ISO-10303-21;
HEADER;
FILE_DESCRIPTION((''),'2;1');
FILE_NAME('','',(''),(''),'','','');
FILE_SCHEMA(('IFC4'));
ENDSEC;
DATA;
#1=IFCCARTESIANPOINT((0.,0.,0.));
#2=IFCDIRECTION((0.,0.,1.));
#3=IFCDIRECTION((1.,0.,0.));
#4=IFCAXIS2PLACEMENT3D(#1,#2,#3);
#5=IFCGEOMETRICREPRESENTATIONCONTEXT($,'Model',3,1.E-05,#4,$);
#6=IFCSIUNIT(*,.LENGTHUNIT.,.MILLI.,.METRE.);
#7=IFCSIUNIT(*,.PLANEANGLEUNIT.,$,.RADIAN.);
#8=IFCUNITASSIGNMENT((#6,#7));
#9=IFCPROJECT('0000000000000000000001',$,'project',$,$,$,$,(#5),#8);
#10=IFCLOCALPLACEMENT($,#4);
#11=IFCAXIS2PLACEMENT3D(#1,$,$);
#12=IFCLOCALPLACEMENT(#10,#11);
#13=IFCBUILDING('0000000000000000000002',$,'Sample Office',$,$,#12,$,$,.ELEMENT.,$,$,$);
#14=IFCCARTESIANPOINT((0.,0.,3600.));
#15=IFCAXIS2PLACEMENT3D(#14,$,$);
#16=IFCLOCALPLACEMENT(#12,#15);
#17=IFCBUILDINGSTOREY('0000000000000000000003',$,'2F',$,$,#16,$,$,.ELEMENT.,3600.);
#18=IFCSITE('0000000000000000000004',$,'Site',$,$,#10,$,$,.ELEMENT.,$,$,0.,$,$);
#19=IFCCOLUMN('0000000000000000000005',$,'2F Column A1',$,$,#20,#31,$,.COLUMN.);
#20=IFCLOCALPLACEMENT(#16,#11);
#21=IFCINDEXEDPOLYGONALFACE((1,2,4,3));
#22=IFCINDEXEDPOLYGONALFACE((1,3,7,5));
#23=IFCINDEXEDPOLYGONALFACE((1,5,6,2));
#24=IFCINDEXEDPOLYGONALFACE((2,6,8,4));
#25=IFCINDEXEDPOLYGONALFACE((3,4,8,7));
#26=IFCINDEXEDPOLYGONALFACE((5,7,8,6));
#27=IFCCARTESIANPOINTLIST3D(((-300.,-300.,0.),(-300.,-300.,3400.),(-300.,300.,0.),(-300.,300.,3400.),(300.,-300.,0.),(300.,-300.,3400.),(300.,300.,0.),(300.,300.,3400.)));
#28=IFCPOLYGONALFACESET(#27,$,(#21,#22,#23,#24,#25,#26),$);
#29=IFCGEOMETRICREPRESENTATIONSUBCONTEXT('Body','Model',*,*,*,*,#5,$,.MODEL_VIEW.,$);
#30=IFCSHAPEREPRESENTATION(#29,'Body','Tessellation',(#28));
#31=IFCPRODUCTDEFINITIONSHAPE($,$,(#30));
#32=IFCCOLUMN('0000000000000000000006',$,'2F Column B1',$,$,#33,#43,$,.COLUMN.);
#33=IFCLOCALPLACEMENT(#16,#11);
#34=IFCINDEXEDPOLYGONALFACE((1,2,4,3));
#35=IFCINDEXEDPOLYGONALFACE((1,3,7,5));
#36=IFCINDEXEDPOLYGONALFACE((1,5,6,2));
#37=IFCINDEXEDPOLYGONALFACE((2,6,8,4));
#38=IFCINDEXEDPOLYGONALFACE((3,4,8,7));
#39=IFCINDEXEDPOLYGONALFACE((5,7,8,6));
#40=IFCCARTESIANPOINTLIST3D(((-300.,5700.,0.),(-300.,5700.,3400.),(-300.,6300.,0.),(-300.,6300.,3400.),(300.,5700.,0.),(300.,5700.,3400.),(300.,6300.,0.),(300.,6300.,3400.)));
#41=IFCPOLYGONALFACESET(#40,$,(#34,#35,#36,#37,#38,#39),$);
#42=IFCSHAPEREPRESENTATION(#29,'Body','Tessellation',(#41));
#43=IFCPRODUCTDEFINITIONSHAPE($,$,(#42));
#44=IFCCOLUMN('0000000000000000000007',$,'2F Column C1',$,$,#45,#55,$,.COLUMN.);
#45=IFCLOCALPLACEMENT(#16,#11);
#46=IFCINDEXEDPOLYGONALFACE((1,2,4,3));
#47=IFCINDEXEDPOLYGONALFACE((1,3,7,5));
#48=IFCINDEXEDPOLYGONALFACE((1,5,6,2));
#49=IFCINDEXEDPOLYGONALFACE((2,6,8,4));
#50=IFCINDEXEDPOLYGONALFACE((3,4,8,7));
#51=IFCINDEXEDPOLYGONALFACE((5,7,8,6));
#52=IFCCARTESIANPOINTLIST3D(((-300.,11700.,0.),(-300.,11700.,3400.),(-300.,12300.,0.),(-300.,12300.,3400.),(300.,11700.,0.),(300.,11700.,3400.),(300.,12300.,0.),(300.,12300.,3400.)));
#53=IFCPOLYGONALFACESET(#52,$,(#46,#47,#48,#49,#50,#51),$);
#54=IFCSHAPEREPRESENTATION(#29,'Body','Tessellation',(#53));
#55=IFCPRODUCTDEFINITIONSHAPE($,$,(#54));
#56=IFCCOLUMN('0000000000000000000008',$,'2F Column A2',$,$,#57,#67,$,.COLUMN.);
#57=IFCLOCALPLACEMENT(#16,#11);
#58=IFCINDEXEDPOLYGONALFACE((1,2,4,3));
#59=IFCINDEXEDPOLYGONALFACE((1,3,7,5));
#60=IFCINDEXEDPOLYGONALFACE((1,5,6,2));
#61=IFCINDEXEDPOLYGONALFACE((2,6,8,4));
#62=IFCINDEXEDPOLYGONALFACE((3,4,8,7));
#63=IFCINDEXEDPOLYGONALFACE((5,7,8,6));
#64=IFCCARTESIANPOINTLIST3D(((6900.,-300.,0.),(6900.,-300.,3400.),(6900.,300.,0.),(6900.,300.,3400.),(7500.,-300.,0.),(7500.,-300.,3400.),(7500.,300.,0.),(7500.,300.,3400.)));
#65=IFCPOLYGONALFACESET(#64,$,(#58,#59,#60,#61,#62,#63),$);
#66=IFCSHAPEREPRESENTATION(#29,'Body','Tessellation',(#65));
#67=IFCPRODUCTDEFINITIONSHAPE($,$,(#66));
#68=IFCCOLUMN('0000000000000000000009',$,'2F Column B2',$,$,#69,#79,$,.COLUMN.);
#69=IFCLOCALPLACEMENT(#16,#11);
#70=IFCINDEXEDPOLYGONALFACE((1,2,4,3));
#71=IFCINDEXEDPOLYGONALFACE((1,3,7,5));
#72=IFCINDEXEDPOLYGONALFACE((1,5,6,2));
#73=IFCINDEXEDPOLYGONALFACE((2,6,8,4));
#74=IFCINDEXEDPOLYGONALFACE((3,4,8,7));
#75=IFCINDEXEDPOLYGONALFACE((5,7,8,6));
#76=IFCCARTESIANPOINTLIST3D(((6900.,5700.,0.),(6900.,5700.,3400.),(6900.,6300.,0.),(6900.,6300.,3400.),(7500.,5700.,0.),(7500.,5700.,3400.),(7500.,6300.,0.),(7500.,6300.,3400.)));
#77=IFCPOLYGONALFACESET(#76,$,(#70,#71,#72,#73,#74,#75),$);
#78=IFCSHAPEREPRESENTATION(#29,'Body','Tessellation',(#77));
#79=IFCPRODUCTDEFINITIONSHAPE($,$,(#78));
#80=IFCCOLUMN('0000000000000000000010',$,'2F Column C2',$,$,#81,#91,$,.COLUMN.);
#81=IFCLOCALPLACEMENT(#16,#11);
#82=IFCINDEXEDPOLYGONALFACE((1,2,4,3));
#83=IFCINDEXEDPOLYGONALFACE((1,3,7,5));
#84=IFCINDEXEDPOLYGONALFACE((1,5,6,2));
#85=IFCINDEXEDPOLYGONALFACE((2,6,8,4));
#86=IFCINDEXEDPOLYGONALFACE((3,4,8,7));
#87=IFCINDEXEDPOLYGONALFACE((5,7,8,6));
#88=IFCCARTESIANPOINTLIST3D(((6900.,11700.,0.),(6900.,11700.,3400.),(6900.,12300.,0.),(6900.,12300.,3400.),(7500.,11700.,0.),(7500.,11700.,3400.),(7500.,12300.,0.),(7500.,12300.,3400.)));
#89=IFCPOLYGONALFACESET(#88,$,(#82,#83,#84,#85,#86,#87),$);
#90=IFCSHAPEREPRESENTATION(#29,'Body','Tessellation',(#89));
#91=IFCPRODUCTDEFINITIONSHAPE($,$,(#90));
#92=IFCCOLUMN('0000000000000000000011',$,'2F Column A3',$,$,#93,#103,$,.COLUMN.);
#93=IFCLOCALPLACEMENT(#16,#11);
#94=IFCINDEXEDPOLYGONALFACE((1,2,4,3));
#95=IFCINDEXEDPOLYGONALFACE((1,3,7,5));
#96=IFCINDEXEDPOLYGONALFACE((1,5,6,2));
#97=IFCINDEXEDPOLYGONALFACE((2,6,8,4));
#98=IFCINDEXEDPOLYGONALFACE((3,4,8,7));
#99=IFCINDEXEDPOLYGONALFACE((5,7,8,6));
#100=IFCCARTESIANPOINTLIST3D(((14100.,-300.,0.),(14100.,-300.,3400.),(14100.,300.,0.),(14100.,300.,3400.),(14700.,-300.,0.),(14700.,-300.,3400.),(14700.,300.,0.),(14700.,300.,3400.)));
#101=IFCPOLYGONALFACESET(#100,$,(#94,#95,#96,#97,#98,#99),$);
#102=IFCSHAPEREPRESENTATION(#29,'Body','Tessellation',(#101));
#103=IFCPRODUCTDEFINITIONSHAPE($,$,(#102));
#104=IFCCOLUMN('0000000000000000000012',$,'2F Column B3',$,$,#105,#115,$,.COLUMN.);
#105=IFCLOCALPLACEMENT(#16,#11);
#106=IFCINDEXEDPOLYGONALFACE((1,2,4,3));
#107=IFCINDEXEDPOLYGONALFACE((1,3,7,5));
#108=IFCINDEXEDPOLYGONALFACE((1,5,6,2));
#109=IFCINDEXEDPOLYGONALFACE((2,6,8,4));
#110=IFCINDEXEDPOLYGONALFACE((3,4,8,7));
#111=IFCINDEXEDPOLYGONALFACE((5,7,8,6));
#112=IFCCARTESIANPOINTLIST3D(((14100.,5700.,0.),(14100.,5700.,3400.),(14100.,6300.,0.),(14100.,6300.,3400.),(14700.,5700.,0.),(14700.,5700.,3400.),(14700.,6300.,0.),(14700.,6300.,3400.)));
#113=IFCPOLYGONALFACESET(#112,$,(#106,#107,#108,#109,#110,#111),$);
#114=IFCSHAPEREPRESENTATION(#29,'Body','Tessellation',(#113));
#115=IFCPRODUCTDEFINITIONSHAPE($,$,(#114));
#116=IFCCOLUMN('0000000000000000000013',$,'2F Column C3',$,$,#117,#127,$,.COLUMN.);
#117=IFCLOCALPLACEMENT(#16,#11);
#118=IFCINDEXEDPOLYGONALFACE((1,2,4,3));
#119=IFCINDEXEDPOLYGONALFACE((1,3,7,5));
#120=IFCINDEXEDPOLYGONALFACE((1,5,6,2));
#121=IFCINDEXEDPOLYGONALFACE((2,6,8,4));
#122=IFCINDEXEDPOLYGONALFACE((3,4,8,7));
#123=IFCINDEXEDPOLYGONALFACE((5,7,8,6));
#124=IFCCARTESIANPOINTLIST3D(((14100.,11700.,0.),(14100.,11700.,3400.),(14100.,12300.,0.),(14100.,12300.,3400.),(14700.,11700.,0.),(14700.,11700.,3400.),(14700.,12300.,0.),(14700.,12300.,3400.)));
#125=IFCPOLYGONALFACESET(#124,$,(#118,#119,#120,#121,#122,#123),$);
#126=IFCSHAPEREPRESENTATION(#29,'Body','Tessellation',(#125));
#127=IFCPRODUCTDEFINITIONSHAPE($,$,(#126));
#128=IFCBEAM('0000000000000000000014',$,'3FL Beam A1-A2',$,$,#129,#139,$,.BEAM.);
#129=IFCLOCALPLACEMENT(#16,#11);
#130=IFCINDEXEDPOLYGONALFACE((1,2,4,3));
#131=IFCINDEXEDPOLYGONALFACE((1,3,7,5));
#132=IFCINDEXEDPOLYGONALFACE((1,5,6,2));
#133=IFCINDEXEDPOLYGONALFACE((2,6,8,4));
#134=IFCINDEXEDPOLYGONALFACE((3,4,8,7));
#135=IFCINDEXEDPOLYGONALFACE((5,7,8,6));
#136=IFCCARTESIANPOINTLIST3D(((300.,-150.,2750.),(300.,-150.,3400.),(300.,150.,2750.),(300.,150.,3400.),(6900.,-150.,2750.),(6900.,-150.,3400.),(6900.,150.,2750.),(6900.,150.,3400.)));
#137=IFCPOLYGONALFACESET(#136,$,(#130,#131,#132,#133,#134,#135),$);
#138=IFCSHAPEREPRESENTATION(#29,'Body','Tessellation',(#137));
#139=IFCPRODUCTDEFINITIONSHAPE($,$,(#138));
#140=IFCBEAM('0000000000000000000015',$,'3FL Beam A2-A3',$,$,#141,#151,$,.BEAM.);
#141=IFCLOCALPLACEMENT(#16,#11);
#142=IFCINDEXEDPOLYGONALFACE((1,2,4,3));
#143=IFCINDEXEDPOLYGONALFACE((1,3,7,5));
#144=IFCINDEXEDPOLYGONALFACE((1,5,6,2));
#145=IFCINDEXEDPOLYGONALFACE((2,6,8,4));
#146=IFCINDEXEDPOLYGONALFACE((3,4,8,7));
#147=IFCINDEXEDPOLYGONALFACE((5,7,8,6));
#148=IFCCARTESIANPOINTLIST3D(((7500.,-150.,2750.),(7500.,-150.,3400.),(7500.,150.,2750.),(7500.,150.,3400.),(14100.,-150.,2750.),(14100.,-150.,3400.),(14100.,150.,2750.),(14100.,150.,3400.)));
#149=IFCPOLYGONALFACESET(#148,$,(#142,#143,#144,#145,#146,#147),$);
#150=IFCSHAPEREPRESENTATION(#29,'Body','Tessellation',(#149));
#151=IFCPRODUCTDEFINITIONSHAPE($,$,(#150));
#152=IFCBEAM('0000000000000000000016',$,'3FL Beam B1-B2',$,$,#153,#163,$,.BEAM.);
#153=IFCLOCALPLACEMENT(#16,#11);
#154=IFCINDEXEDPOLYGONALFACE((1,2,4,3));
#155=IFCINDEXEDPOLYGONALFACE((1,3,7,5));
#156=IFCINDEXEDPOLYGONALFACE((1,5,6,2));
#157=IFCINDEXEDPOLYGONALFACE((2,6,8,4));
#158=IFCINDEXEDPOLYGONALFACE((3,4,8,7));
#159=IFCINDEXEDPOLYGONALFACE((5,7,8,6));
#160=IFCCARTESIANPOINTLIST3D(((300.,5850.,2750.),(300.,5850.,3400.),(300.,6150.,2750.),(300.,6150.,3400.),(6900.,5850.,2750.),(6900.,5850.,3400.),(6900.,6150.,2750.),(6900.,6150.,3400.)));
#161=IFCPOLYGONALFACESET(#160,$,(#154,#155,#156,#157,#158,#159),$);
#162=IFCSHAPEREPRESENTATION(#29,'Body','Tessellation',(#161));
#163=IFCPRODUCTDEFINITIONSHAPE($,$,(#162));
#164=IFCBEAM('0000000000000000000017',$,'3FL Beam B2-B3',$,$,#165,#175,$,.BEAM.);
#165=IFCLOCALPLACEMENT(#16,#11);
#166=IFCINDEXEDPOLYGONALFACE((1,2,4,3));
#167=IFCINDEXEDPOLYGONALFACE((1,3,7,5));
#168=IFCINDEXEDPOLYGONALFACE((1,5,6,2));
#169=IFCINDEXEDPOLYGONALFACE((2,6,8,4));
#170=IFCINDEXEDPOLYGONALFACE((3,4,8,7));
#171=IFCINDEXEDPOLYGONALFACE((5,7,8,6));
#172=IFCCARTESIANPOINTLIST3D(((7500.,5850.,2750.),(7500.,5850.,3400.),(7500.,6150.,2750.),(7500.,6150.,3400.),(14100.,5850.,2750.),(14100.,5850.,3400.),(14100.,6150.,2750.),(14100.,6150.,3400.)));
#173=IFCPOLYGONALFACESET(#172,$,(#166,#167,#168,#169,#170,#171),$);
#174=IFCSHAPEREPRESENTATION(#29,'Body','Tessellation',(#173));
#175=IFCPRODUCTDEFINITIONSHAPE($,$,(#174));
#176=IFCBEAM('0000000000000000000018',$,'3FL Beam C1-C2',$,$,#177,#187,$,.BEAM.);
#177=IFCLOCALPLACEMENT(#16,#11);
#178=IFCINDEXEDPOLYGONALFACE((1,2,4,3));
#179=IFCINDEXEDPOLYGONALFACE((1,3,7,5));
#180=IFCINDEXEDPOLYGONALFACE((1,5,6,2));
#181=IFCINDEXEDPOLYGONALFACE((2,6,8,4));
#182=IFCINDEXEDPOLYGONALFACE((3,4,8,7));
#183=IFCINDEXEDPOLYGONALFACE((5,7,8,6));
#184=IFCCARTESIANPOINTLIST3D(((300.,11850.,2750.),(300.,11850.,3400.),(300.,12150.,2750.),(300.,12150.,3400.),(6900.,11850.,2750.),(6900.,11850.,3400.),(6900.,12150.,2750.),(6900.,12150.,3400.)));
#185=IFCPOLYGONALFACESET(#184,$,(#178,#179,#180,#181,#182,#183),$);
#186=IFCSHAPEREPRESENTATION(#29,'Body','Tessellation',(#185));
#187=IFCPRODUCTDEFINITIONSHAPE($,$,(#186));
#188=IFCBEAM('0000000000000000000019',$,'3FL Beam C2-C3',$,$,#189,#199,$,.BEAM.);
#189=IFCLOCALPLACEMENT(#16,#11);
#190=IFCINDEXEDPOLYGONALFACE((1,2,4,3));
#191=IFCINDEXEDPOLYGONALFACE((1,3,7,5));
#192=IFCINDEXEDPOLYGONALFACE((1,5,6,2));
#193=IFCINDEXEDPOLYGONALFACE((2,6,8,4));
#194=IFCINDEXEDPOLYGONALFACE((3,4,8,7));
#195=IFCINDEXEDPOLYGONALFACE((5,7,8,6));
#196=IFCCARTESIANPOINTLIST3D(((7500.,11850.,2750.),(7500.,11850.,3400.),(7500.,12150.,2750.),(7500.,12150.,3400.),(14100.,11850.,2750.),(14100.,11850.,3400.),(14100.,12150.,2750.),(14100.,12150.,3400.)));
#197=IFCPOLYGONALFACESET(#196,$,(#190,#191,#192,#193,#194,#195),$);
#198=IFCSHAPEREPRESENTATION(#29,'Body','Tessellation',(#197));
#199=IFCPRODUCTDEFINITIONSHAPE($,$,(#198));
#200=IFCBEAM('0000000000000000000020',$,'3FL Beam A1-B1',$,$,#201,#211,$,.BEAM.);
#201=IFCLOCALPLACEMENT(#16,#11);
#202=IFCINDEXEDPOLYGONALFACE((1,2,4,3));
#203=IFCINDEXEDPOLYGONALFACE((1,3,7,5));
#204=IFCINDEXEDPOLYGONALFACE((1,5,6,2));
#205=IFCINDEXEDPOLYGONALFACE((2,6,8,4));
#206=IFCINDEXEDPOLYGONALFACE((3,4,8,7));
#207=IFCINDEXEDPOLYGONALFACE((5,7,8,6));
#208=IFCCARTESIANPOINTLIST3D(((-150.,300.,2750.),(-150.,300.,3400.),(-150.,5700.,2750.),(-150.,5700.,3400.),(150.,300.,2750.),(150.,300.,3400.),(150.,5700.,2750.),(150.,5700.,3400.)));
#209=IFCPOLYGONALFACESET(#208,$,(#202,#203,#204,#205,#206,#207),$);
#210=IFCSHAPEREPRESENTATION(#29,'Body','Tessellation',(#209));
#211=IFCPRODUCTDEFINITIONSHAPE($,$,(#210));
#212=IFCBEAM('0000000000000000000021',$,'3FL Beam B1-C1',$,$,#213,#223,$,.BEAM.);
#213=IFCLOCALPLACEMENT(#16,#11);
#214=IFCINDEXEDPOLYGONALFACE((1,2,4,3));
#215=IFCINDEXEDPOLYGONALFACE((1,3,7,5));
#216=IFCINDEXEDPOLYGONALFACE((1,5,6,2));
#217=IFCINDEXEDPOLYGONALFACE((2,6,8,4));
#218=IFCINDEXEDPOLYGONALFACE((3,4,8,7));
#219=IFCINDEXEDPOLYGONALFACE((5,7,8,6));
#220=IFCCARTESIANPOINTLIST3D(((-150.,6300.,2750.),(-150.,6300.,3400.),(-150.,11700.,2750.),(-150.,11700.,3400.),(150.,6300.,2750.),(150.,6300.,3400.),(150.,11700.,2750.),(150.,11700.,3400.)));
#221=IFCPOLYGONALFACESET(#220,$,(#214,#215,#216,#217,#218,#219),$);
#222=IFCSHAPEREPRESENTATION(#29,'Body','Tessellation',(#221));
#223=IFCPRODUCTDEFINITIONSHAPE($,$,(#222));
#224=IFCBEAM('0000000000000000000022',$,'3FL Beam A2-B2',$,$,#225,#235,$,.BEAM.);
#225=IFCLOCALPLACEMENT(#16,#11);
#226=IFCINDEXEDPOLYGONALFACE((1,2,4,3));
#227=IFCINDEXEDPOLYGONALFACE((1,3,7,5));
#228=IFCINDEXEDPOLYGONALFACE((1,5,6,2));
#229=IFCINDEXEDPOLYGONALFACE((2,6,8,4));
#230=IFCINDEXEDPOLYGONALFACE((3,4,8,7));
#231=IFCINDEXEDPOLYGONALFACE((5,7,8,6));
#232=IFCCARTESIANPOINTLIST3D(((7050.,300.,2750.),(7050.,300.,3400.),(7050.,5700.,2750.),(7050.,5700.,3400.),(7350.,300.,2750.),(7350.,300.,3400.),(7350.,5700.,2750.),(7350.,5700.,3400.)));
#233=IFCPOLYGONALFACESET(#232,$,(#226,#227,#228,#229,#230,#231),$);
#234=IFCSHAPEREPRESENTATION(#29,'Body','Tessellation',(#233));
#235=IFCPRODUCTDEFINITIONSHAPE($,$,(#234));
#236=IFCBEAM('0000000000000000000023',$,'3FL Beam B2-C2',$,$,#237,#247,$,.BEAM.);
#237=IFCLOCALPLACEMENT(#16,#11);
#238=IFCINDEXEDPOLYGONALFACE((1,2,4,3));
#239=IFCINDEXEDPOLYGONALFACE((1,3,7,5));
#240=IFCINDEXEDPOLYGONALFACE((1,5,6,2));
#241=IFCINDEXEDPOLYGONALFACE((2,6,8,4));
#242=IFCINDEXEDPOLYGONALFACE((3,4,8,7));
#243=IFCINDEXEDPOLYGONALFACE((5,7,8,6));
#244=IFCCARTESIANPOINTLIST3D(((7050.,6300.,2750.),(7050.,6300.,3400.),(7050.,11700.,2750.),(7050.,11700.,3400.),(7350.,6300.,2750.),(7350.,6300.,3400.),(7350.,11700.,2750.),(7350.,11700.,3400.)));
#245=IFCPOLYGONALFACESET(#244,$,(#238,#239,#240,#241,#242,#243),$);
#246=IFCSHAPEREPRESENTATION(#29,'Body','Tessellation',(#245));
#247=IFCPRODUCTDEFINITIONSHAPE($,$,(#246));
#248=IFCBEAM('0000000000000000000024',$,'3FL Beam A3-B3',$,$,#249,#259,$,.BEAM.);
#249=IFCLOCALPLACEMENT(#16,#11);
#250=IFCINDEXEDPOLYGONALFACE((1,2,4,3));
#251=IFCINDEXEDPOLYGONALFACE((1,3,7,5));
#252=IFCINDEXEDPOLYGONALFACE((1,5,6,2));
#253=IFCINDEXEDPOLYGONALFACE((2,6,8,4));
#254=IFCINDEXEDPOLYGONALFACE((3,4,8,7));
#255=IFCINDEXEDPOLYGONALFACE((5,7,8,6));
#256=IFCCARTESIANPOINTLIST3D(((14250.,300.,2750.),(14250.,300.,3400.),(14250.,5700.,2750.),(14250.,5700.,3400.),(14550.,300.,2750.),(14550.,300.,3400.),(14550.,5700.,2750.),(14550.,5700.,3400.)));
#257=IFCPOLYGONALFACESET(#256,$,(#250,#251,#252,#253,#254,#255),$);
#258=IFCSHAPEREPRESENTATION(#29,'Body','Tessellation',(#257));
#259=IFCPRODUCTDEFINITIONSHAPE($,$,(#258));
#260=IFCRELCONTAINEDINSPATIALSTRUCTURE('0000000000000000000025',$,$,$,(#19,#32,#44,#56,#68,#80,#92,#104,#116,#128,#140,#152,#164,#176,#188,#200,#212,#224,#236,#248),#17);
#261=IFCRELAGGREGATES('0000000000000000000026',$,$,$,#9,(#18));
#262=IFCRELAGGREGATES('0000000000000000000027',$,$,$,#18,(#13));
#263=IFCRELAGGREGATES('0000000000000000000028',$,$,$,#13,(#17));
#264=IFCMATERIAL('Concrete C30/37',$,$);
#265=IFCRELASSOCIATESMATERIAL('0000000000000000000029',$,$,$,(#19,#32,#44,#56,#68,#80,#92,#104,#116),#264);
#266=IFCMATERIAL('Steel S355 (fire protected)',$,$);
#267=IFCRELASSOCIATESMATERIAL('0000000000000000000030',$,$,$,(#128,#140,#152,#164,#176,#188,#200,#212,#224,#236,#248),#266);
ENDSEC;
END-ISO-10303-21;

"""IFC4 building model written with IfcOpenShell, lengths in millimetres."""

from ifc_helpers import new_model, si_unit, frame, origin, origin_with_axes, origin_2d, place, context, subcontext, project, spatial, rectangle, extrude, material, element, save


model = new_model("IFC4")

# Units and contexts
model_context = context("Model", 3, precision=1e-05, world=origin_with_axes())
body_context = subcontext(model_context, "Body", "Model", "MODEL_VIEW")
ifc_project = project(units=[si_unit("LENGTHUNIT", "METRE", prefix="MILLI"), si_unit("PLANEANGLEUNIT", "RADIAN")], contexts=[model_context])

# Site, building, storey
site_placement = place(None, origin_with_axes())
site = spatial("IfcSite", under=ifc_project, at=site_placement, Name="Site", CompositionType="ELEMENT", RefElevation=0.0)
building_placement = place(site_placement, origin())
building = spatial("IfcBuilding", under=site, at=building_placement, Name="Sample Office", CompositionType="ELEMENT")
storey_placement = place(building_placement, frame((0.0, 0.0, 3600.0)))
storey = spatial("IfcBuildingStorey", under=building, at=storey_placement, Name="2F", CompositionType="ELEMENT", Elevation=3600.0)

# Columns
ifc_material_1 = material(Name="Concrete C30/37")
for number, where, name in (
    (1, (0.0, 0.0, 0.0), "2F Column A1"),
    (2, (0.0, 6000.0, 0.0), "2F Column B1"),
    (3, (0.0, 12000.0, 0.0), "2F Column C1"),
    (4, (7200.0, 0.0, 0.0), "2F Column A2"),
    (5, (7200.0, 6000.0, 0.0), "2F Column B2"),
    (6, (7200.0, 12000.0, 0.0), "2F Column C2"),
    (7, (14400.0, 0.0, 0.0), "2F Column A3"),
    (8, (14400.0, 6000.0, 0.0), "2F Column B3"),
    (9, (14400.0, 12000.0, 0.0), "2F Column C3"),
):
    element("IfcColumn", number, at=place(storey_placement, frame(where)), inside=storey, material=ifc_material_1, Name=name, PredefinedType="COLUMN", context=body_context, shape_type="SweptSolid", body=[
        extrude(rectangle(XDim=600.0, YDim=600.0, at=origin_2d()), origin(), (0.0, 0.0, 1.0), 3400.0),
    ])

# Beams
ifc_material_2 = material(Name="Steel S355 (fire protected)")
for number, where, name in (
    (10, (3600.0, 0.0, 2750.0), "3FL Beam A1-A2"),
    (11, (10800.0, 0.0, 2750.0), "3FL Beam A2-A3"),
    (12, (3600.0, 6000.0, 2750.0), "3FL Beam B1-B2"),
    (13, (10800.0, 6000.0, 2750.0), "3FL Beam B2-B3"),
    (14, (3600.0, 12000.0, 2750.0), "3FL Beam C1-C2"),
    (15, (10800.0, 12000.0, 2750.0), "3FL Beam C2-C3"),
):
    element("IfcBeam", number, at=place(storey_placement, frame(where)), inside=storey, material=ifc_material_2, Name=name, PredefinedType="BEAM", context=body_context, shape_type="SweptSolid", body=[
        extrude(rectangle(XDim=6600.0, YDim=300.0, at=origin_2d()), origin(), (0.0, 0.0, 1.0), 650.0),
    ])
for number, where, name in (
    (16, (0.0, 3000.0, 2750.0), "3FL Beam A1-B1"),
    (17, (0.0, 9000.0, 2750.0), "3FL Beam B1-C1"),
    (18, (7200.0, 3000.0, 2750.0), "3FL Beam A2-B2"),
    (19, (7200.0, 9000.0, 2750.0), "3FL Beam B2-C2"),
    (20, (14400.0, 3000.0, 2750.0), "3FL Beam A3-B3"),
):
    element("IfcBeam", number, at=place(storey_placement, frame(where)), inside=storey, material=ifc_material_2, Name=name, PredefinedType="BEAM", context=body_context, shape_type="SweptSolid", body=[
        extrude(rectangle(XDim=300.0, YDim=5400.0, at=origin_2d()), origin(), (0.0, 0.0, 1.0), 650.0),
    ])

save(model, "model.ifc")
